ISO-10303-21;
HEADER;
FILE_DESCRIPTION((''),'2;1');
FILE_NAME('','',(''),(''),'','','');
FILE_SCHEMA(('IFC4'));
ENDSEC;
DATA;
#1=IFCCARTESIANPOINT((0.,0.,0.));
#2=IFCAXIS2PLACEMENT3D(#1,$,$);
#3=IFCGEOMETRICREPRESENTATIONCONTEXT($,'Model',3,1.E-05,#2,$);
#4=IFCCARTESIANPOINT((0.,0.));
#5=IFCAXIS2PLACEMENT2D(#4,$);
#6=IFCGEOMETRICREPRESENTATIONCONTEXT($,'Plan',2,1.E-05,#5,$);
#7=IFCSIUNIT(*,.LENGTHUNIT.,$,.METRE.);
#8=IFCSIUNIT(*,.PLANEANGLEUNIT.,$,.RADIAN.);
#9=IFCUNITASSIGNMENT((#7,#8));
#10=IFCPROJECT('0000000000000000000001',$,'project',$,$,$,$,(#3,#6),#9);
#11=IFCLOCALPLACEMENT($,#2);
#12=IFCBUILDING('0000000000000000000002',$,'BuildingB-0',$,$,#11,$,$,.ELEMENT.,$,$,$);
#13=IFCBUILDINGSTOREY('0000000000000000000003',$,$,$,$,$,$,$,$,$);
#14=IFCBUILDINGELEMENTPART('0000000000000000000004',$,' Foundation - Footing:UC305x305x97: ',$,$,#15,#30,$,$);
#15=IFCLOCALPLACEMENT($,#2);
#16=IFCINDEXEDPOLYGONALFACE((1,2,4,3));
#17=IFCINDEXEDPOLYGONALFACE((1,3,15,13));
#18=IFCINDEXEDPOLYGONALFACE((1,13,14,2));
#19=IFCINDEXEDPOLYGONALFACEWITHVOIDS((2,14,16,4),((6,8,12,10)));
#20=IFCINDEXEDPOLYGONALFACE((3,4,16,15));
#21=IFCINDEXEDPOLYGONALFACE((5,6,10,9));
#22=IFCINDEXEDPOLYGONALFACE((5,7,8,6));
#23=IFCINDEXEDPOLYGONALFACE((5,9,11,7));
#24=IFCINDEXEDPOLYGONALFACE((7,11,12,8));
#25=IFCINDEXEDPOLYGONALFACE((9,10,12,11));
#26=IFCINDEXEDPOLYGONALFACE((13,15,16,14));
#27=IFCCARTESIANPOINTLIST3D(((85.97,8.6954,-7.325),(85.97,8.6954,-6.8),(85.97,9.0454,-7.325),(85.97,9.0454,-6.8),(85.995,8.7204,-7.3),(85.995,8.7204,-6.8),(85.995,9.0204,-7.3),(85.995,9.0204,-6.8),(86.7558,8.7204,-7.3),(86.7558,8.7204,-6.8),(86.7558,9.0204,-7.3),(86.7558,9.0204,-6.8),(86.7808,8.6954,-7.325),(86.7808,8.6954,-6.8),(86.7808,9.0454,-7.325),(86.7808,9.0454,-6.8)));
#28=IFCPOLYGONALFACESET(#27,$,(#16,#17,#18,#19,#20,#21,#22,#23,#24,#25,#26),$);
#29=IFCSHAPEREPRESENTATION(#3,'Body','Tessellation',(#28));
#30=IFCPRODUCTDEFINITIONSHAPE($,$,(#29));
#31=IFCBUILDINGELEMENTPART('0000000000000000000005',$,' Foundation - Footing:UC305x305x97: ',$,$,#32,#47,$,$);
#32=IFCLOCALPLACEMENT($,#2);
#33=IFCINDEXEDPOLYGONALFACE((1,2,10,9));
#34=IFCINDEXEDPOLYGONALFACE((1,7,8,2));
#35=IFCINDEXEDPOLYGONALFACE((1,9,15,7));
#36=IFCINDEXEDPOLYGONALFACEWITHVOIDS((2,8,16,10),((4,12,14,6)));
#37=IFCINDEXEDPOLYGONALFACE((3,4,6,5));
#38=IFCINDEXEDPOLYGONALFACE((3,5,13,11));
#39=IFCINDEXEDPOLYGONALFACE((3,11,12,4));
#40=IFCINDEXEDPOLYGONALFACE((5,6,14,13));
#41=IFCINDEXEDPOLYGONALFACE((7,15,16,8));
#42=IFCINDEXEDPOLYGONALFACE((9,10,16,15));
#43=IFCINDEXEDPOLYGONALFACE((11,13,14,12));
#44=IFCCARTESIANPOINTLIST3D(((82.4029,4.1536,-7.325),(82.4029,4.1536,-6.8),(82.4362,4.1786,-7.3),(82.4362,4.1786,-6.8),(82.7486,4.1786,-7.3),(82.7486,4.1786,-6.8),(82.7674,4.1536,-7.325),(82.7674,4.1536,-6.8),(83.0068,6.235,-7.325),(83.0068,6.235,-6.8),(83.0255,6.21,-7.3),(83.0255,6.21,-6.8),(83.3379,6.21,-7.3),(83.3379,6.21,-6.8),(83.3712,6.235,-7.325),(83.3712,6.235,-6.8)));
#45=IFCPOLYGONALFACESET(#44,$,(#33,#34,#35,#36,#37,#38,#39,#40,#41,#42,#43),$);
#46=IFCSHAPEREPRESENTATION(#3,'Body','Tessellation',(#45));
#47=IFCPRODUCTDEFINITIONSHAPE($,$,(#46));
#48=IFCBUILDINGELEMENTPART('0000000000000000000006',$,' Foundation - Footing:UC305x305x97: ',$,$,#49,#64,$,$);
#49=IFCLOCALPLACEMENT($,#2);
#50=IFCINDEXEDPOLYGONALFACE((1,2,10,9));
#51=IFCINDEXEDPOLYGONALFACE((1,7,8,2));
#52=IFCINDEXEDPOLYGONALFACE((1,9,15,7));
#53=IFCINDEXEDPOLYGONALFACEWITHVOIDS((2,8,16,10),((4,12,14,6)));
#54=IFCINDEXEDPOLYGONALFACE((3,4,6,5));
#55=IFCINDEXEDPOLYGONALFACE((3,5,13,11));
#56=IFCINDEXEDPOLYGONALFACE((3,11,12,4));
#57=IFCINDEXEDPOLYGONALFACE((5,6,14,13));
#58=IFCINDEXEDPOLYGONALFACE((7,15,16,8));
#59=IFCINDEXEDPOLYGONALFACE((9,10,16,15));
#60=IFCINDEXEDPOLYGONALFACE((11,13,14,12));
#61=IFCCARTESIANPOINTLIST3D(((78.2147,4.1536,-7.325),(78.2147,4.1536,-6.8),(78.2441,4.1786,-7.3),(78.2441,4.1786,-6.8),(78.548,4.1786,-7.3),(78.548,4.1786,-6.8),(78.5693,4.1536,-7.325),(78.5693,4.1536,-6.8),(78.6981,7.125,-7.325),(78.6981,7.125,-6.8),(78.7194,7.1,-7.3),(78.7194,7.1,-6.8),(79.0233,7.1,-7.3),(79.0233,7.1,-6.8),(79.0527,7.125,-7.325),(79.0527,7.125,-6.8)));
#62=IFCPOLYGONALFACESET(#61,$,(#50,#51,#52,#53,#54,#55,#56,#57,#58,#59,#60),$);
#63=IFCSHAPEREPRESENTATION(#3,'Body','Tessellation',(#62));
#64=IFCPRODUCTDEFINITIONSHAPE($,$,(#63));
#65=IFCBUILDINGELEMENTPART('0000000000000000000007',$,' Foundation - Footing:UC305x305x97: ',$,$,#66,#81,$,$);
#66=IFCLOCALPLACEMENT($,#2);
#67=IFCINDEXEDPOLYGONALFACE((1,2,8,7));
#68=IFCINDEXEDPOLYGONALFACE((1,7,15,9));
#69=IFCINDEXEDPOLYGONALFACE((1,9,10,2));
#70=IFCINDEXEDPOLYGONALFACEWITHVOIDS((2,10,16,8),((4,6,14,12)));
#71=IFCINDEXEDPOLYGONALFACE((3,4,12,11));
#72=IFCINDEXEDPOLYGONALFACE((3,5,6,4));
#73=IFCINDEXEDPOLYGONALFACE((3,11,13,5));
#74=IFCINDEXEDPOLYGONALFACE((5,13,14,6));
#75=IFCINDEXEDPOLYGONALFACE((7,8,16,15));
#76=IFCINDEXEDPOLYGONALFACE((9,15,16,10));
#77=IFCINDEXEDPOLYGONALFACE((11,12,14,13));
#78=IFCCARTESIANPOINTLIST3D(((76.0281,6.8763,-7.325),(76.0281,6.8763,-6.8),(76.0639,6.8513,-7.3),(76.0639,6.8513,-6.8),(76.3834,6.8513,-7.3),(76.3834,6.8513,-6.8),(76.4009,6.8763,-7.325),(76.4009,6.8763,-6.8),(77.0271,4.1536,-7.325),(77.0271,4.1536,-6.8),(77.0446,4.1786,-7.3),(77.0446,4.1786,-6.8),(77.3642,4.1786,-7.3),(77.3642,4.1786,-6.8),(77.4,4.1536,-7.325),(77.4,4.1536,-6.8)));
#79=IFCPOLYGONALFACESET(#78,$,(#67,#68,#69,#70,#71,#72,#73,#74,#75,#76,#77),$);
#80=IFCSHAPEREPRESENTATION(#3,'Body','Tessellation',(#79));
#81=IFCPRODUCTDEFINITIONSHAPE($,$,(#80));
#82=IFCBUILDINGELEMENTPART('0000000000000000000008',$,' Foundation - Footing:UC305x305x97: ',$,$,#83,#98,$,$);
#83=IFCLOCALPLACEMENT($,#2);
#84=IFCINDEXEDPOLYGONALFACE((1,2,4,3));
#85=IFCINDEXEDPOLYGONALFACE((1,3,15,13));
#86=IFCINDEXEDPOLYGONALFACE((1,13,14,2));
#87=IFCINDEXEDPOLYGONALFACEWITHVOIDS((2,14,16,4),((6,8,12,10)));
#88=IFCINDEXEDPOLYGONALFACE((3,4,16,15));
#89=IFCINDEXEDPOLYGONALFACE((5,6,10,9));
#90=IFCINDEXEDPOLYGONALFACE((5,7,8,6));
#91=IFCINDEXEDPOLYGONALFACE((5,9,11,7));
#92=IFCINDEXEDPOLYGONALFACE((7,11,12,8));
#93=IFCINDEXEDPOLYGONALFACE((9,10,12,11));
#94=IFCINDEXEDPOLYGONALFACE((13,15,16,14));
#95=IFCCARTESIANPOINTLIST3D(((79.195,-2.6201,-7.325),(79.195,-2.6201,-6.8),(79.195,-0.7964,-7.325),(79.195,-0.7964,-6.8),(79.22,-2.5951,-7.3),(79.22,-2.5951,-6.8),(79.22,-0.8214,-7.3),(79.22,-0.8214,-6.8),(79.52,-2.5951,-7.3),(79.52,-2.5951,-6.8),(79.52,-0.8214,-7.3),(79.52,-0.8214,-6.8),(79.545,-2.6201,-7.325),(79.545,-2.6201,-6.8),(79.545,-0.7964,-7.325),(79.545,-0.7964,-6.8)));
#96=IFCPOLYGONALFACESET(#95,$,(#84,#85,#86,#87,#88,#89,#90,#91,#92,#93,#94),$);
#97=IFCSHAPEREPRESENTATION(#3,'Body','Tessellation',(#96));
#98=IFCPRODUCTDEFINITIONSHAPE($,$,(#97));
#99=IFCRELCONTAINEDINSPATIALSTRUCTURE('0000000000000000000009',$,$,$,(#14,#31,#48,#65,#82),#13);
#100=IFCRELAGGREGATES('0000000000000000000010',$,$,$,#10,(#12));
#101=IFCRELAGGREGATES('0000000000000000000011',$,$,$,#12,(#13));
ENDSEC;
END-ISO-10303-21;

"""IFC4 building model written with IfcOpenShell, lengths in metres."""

from ifc_helpers import new_model, si_unit, origin, origin_2d, place, context, project, spatial, polyline, outline, extrude, element, save


model = new_model("IFC4")

# Units and contexts
model_context = context("Model", 3, precision=1e-05, world=origin())
plan_context = context("Plan", 2, precision=1e-05, world=origin_2d())
ifc_project = project(units=[si_unit("LENGTHUNIT", "METRE"), si_unit("PLANEANGLEUNIT", "RADIAN")], contexts=[model_context, plan_context])

# Building, storey
building_placement = place(None, origin())
building = spatial("IfcBuilding", under=ifc_project, at=building_placement, Name="BuildingB-0", CompositionType="ELEMENT")
storey = spatial("IfcBuildingStorey", under=building)

# Building element parts, openings
building_element_part_1 = element("IfcBuildingElementPart", 1, inside=storey, Name=" Foundation - Footing:UC305x305x97: ", context=model_context, shape_type="SweptSolid", body=[
    extrude(outline(polyline([(86.7808, 8.6954, -7.325), (85.97, 8.6954, -7.325), (85.97, 9.0454, -7.325), (86.7808, 9.0454, -7.325), (86.7808, 8.6954, -7.325)])), None, (0.0, 0.0, 1.0), 0.525),
])
element("IfcOpeningElement", 2, inside=storey, cuts=building_element_part_1, context=model_context, shape_type="SweptSolid", body=[
    extrude(outline(polyline([(86.7558, 8.7204, -7.3), (85.995, 8.7204, -7.3), (85.995, 9.0204, -7.3), (86.7558, 9.0204, -7.3), (86.7558, 8.7204, -7.3)])), None, (0.0, 0.0, 1.0), 0.5),
])
building_element_part_2 = element("IfcBuildingElementPart", 3, inside=storey, Name=" Foundation - Footing:UC305x305x97: ", context=model_context, shape_type="SweptSolid", body=[
    extrude(outline(polyline([(82.7674, 4.1536, -7.325), (82.4029, 4.1536, -7.325), (83.0068, 6.235, -7.325), (83.3712, 6.235, -7.325), (82.7674, 4.1536, -7.325)])), None, (0.0, 0.0, 1.0), 0.525),
])
element("IfcOpeningElement", 4, inside=storey, cuts=building_element_part_2, context=model_context, shape_type="SweptSolid", body=[
    extrude(outline(polyline([(82.7486, 4.1786, -7.3), (82.4362, 4.1786, -7.3), (83.0255, 6.21, -7.3), (83.3379, 6.21, -7.3), (82.7486, 4.1786, -7.3)])), None, (0.0, 0.0, 1.0), 0.5),
])
building_element_part_3 = element("IfcBuildingElementPart", 5, inside=storey, Name=" Foundation - Footing:UC305x305x97: ", context=model_context, shape_type="SweptSolid", body=[
    extrude(outline(polyline([(78.5693, 4.1536, -7.325), (78.2147, 4.1536, -7.325), (78.6981, 7.125, -7.325), (79.0527, 7.125, -7.325), (78.5693, 4.1536, -7.325)])), None, (0.0, 0.0, 1.0), 0.525),
])
element("IfcOpeningElement", 6, inside=storey, cuts=building_element_part_3, context=model_context, shape_type="SweptSolid", body=[
    extrude(outline(polyline([(78.548, 4.1786, -7.3), (78.2441, 4.1786, -7.3), (78.7194, 7.1, -7.3), (79.0233, 7.1, -7.3), (78.548, 4.1786, -7.3)])), None, (0.0, 0.0, 1.0), 0.5),
])
building_element_part_4 = element("IfcBuildingElementPart", 7, inside=storey, Name=" Foundation - Footing:UC305x305x97: ", context=model_context, shape_type="SweptSolid", body=[
    extrude(outline(polyline([(77.4, 4.1536, -7.325), (77.0271, 4.1536, -7.325), (76.0281, 6.8763, -7.325), (76.4009, 6.8763, -7.325), (77.4, 4.1536, -7.325)])), None, (0.0, 0.0, 1.0), 0.525),
])
element("IfcOpeningElement", 8, inside=storey, cuts=building_element_part_4, context=model_context, shape_type="SweptSolid", body=[
    extrude(outline(polyline([(77.3642, 4.1786, -7.3), (77.0446, 4.1786, -7.3), (76.0639, 6.8513, -7.3), (76.3834, 6.8513, -7.3), (77.3642, 4.1786, -7.3)])), None, (0.0, 0.0, 1.0), 0.5),
])
building_element_part_5 = element("IfcBuildingElementPart", 9, inside=storey, Name=" Foundation - Footing:UC305x305x97: ", context=model_context, shape_type="SweptSolid", body=[
    extrude(outline(polyline([(79.545, -2.6201, -7.325), (79.195, -2.6201, -7.325), (79.195, -0.7964, -7.325), (79.545, -0.7964, -7.325), (79.545, -2.6201, -7.325)])), None, (0.0, 0.0, 1.0), 0.525),
])
element("IfcOpeningElement", 10, inside=storey, cuts=building_element_part_5, context=model_context, shape_type="SweptSolid", body=[
    extrude(outline(polyline([(79.52, -2.5951, -7.3), (79.22, -2.5951, -7.3), (79.22, -0.8214, -7.3), (79.52, -0.8214, -7.3), (79.52, -2.5951, -7.3)])), None, (0.0, 0.0, 1.0), 0.5),
])

save(model, "model.ifc")
